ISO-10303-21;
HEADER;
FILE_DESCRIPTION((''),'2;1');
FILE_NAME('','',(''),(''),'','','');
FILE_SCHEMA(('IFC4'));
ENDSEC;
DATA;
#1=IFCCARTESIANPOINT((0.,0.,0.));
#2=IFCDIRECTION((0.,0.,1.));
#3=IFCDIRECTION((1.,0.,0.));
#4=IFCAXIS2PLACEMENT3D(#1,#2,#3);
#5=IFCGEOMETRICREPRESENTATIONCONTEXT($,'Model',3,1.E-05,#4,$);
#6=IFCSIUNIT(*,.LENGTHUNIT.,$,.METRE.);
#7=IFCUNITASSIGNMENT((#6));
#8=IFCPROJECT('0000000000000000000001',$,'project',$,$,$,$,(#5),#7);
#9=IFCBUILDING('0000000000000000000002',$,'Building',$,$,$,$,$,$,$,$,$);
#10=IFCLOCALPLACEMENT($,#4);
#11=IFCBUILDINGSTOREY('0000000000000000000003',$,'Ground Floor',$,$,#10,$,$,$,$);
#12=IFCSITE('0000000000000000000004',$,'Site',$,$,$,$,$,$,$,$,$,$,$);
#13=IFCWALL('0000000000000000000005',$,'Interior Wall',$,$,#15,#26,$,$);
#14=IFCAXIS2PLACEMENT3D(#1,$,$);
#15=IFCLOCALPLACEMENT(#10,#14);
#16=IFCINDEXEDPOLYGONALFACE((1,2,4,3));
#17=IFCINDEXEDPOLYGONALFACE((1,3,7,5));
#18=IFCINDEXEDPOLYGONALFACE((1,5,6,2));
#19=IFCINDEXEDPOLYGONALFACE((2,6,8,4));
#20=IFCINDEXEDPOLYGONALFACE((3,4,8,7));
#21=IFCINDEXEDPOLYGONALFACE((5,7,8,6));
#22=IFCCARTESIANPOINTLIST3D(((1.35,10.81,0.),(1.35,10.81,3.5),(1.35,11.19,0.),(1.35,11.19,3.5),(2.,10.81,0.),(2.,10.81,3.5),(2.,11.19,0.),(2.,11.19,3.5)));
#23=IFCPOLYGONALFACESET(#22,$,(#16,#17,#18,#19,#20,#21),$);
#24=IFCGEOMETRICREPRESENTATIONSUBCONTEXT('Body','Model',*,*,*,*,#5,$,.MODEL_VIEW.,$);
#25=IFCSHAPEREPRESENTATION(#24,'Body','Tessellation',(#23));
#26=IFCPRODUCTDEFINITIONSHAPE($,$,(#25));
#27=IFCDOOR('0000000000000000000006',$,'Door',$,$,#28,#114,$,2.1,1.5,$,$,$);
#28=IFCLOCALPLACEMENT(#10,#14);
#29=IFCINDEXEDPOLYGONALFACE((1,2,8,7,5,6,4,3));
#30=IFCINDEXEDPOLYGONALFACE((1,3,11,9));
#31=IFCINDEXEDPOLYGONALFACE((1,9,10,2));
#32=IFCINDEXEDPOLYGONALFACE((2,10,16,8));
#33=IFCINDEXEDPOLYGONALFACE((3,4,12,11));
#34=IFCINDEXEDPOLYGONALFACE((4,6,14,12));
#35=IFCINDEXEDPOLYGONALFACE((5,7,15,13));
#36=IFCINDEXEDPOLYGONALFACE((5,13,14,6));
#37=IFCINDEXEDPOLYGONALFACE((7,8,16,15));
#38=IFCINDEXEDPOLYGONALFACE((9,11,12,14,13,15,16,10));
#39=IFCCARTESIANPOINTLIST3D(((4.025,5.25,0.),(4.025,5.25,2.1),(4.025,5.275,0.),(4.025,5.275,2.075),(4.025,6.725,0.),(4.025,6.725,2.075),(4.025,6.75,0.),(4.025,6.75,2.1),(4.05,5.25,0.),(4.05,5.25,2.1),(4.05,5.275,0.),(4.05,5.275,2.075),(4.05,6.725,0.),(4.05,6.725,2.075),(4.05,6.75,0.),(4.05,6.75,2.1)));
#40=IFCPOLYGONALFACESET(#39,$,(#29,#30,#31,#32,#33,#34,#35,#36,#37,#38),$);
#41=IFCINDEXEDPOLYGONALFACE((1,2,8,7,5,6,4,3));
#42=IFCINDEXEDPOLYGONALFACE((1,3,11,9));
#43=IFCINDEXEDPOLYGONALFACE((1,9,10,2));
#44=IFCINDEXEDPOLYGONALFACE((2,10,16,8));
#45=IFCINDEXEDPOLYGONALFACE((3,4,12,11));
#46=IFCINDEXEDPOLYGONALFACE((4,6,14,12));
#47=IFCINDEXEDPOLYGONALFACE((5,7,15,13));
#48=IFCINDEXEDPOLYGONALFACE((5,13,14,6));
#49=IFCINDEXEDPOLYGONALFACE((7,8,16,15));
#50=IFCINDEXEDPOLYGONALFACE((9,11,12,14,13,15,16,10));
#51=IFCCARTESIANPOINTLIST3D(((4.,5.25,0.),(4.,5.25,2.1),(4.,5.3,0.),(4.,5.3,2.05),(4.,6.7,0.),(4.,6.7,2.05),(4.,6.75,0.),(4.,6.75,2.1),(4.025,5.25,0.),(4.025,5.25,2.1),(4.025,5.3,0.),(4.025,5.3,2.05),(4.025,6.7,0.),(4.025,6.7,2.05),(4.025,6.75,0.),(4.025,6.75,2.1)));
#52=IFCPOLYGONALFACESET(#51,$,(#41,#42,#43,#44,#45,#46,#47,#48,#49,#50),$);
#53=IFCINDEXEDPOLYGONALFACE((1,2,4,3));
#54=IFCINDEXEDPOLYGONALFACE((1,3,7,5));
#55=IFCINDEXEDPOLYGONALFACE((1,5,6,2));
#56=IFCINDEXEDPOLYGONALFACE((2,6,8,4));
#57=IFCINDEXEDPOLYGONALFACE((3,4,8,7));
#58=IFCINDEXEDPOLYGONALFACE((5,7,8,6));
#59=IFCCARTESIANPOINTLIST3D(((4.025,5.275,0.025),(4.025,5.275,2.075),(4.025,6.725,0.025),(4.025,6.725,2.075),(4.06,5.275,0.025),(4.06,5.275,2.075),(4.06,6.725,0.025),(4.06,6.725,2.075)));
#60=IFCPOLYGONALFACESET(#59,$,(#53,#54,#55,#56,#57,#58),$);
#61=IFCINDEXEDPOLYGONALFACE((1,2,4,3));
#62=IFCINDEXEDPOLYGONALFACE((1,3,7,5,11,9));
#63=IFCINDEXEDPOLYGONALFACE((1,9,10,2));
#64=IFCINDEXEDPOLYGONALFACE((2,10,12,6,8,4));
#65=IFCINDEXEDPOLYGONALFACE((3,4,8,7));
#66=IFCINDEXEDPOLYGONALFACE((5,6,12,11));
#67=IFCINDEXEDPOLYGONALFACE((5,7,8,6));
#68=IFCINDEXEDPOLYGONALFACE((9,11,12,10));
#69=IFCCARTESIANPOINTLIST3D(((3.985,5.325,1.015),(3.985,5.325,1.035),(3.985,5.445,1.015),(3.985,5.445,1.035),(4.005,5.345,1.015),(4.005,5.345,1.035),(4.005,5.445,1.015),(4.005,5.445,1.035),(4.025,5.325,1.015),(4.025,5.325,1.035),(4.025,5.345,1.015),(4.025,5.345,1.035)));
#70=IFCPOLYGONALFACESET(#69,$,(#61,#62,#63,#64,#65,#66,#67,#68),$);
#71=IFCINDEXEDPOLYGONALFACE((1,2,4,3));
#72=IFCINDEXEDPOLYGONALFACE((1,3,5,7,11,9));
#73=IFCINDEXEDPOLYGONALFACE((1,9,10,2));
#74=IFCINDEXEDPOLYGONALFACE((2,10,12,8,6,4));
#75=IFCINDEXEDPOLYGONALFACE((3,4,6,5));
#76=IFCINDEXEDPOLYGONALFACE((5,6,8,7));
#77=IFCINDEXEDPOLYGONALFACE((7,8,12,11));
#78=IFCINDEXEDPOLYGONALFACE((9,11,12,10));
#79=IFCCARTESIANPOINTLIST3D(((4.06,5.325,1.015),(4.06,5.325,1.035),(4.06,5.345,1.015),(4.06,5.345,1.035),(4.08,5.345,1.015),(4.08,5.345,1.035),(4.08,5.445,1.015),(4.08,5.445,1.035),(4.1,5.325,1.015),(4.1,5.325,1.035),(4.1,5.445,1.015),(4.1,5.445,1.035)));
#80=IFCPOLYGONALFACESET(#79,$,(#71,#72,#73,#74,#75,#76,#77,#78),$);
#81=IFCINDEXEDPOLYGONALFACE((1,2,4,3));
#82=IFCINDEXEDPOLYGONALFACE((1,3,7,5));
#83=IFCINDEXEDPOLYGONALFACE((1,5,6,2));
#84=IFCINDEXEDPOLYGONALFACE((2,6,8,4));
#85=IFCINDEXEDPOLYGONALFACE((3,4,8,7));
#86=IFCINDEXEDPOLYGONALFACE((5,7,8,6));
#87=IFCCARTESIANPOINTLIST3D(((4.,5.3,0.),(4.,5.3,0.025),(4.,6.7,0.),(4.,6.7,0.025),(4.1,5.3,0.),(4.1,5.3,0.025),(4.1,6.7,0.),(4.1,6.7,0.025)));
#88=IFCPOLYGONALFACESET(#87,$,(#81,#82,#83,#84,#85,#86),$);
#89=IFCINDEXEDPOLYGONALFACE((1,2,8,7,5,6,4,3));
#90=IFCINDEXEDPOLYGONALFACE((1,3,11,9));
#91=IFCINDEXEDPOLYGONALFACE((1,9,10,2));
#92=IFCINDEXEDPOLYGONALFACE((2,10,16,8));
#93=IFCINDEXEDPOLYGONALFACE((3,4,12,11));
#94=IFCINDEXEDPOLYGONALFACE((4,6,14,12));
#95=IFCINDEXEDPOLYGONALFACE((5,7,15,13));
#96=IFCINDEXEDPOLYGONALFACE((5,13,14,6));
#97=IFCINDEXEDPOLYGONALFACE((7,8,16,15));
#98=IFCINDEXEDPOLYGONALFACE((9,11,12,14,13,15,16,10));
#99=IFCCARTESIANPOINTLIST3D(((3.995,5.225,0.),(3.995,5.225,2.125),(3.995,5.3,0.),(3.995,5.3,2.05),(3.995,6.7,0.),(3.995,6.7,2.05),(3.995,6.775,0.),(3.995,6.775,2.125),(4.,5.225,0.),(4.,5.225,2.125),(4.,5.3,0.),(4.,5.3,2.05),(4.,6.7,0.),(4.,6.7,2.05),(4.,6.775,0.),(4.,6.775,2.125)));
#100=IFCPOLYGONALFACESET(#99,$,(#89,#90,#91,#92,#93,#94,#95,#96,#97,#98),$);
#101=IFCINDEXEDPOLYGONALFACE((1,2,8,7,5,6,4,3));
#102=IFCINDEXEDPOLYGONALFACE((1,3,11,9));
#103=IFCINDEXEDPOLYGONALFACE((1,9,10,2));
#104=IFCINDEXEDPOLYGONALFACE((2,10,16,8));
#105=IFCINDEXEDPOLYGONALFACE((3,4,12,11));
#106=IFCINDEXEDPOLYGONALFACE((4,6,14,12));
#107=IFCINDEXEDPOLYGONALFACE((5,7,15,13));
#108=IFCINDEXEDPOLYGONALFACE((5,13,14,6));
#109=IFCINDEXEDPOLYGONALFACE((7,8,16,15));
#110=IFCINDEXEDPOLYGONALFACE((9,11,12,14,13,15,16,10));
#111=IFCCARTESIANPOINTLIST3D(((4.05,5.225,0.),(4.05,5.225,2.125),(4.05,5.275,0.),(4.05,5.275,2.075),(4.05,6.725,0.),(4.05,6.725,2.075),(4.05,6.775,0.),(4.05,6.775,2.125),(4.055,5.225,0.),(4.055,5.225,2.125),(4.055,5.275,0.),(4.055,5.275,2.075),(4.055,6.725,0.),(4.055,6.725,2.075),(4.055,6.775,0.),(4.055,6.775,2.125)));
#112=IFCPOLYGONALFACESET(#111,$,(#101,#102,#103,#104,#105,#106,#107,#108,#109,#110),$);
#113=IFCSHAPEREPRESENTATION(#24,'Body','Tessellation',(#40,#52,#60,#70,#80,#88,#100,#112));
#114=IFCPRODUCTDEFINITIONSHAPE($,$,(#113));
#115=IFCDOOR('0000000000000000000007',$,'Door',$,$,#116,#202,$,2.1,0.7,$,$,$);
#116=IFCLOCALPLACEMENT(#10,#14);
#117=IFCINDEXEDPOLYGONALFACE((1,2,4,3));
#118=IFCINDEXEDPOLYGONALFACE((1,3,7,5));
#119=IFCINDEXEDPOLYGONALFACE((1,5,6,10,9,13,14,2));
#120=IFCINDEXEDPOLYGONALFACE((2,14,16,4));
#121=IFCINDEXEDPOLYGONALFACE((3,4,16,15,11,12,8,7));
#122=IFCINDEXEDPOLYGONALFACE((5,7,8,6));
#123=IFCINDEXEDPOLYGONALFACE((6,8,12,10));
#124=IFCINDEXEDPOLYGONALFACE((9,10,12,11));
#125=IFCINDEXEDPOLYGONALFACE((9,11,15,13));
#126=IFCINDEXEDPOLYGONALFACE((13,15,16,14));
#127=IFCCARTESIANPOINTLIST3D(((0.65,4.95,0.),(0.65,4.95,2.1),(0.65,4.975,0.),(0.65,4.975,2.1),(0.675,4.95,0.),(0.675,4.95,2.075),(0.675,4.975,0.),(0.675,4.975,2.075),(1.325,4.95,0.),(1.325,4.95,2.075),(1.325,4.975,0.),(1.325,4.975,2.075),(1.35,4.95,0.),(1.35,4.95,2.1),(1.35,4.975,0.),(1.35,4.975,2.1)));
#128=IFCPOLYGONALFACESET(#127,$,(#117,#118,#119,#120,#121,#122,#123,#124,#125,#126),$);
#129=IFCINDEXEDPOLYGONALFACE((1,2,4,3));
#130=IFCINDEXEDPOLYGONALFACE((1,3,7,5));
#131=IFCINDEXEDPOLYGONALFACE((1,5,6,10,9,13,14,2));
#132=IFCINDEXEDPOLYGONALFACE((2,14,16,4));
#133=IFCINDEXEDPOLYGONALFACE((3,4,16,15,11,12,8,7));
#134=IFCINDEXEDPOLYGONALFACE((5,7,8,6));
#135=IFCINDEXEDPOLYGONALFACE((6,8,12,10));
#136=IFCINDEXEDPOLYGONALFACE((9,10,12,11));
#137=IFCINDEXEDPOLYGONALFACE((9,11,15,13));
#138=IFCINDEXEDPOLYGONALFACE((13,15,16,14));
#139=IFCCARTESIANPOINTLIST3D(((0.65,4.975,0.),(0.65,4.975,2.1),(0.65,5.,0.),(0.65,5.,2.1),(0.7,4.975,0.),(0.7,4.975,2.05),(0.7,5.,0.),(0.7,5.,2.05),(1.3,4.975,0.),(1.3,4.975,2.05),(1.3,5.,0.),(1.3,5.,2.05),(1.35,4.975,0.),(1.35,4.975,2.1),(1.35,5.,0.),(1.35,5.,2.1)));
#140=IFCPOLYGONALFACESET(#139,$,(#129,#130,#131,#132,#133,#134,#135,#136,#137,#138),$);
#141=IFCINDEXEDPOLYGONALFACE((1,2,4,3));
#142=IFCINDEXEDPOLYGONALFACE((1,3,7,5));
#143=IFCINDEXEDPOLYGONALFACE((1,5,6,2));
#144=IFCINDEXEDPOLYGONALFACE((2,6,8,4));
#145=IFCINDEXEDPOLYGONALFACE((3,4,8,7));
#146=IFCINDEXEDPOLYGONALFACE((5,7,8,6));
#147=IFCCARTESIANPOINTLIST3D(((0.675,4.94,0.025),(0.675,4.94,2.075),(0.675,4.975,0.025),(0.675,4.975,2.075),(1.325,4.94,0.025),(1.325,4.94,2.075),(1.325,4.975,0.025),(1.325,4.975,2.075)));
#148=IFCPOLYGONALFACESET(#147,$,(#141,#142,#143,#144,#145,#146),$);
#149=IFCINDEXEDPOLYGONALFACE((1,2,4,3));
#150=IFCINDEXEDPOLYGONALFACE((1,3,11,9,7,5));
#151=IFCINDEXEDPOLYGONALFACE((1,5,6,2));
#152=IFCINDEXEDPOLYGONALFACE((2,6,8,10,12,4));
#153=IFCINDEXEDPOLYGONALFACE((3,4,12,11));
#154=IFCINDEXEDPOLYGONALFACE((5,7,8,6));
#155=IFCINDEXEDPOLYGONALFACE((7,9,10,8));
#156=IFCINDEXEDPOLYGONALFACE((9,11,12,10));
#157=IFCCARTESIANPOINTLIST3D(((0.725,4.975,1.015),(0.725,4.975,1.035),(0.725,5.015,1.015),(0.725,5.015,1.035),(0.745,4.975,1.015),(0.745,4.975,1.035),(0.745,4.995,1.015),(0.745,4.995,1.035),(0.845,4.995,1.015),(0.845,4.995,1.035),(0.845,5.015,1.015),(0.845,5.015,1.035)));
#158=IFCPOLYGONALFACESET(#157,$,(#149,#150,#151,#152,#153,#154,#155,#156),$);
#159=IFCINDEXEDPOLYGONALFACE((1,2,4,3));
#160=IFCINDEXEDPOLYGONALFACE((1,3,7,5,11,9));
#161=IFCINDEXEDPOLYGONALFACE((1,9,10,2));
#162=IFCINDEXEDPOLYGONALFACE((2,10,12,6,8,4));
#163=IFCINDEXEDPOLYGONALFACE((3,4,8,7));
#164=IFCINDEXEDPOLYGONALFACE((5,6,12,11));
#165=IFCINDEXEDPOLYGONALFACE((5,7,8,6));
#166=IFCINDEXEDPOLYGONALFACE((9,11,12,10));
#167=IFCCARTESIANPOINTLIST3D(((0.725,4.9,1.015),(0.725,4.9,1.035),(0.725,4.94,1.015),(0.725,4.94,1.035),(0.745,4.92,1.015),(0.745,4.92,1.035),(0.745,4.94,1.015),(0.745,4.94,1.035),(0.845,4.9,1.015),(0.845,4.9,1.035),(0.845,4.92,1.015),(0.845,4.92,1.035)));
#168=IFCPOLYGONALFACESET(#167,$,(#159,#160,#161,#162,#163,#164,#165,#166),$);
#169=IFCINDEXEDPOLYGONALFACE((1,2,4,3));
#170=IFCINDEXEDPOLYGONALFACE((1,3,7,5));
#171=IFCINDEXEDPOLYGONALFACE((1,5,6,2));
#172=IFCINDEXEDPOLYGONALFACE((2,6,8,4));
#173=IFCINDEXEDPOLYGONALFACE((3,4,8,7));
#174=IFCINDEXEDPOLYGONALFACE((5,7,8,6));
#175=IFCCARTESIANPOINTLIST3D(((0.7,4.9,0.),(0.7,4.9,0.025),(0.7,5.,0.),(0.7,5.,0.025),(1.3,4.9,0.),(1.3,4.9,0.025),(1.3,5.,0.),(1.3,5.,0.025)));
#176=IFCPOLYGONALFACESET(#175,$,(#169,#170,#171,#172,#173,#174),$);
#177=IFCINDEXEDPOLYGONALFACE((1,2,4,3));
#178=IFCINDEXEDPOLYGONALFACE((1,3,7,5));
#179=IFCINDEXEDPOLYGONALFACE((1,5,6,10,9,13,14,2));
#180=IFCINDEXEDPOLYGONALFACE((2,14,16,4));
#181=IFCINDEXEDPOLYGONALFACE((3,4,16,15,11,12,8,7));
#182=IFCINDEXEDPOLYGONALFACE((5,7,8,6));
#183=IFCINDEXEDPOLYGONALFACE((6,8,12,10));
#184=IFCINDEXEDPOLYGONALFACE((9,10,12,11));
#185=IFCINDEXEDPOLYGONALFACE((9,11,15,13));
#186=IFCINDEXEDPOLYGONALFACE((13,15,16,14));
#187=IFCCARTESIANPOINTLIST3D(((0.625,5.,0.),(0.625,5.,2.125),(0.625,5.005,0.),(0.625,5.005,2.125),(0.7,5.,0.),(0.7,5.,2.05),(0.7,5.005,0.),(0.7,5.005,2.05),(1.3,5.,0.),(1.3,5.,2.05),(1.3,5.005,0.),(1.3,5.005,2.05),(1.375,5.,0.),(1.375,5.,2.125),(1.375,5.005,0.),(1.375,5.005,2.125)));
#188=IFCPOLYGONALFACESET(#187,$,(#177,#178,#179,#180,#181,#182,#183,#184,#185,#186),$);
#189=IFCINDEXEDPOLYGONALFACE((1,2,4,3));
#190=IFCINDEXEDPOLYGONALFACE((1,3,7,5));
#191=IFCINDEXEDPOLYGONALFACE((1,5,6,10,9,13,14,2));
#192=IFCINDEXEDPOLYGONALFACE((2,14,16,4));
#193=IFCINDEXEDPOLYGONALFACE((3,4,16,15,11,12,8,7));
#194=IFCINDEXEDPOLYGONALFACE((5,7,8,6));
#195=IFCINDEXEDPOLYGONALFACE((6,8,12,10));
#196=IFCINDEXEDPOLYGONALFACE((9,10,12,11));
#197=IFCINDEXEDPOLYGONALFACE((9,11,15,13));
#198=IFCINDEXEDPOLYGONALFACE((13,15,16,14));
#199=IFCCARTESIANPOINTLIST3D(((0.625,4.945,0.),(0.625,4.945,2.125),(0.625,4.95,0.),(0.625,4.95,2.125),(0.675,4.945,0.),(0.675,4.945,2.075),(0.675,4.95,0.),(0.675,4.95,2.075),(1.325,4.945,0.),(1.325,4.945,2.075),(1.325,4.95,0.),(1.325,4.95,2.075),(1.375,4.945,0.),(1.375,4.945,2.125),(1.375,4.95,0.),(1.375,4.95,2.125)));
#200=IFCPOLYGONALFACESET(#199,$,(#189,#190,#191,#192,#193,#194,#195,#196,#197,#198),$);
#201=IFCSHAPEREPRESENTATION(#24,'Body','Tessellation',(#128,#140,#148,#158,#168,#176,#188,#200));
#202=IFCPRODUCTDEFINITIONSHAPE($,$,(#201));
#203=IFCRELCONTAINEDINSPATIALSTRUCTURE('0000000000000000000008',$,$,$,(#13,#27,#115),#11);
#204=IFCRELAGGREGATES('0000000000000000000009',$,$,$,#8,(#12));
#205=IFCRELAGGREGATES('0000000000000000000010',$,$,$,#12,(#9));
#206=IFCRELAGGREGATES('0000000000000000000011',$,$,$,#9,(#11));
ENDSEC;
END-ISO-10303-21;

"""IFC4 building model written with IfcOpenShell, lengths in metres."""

from ifc_helpers import new_model, si_unit, frame, origin_with_axes, place, context, subcontext, project, spatial, line, indexed_curve, outline, extrude, element, save


model = new_model("IFC4")

# Units and contexts
model_context = context("Model", 3, precision=1e-05, world=origin_with_axes())
body_context = subcontext(model_context, "Body", "Model", "MODEL_VIEW")
ifc_project = project(units=[si_unit("LENGTHUNIT", "METRE")], contexts=[model_context])

# Site, building, storey
site = spatial("IfcSite", under=ifc_project, Name="Site")
building = spatial("IfcBuilding", under=site, Name="Building")
storey_placement = place(None, origin_with_axes())
storey = spatial("IfcBuildingStorey", under=building, at=storey_placement, Name="Ground Floor")

# Wall
wall_1_placement = place(storey_placement, frame((1.35, 11.0, 0.0), z_axis=(0.0, 0.0, 1.0), x_axis=(1.0, 0.0, 0.0)))
element("IfcWall", 1, at=wall_1_placement, inside=storey, Name="Interior Wall", context=body_context, shape_type="SweptSolid", body=[
    extrude(outline(indexed_curve([(0.0, 0.0), (0.0, 0.38), (0.65, 0.38), (0.65, 0.0), (0.0, 0.0)], self_intersect=False)), frame((0.0, -0.19, 0.0), z_axis=(0.0, 0.0, 1.0), x_axis=(1.0, 0.0, 0.0)), (0.0, 0.0, 1.0), 3.5),
])

# Doors
door_1_placement = place(storey_placement, frame((4.0, 6.75, 0.0), z_axis=(0.0, 0.0, 1.0), x_axis=(0.0, -1.0, 0.0)))
element("IfcDoor", 2, at=door_1_placement, inside=storey, Name="Door", OverallHeight=2.1, OverallWidth=1.5, context=body_context, shape_type="SweptSolid", body=[
    extrude(outline(indexed_curve([(0.0, 0.0), (0.0, 2.1), (1.5, 2.1), (1.5, 0.0), (1.475, 0.0), (1.475, 2.075), (0.025, 2.075), (0.025, 0.0)], segments=[line(1, 2, 3, 4, 5, 6, 7, 8, 1)])), frame((0.0, 0.025, 0.0), z_axis=(0.0, -1.0, 0.0), x_axis=(1.0, 0.0, 0.0)), (0.0, 0.0, -1.0), 0.025),
    extrude(outline(indexed_curve([(0.0, 0.0), (0.0, 2.1), (1.5, 2.1), (1.5, 0.0), (1.45, 0.0), (1.45, 2.05), (0.05, 2.05), (0.05, 0.0)], segments=[line(1, 2, 3, 4, 5, 6, 7, 8, 1)])), frame((0.0, 0.0, 0.0), z_axis=(0.0, -1.0, 0.0), x_axis=(1.0, 0.0, 0.0)), (0.0, 0.0, -1.0), 0.025),
    extrude(outline(indexed_curve([(0.0, 0.0), (1.45, 0.0), (1.45, 0.035), (0.0, 0.035)], segments=[line(1, 2, 3, 4, 1)])), frame((0.025, 0.025, 0.025), z_axis=(0.0, 0.0, 1.0), x_axis=(1.0, 0.0, 0.0)), (0.0, 0.0, 1.0), 2.05),
    extrude(outline(indexed_curve([(0.0, 0.0), (0.0, -0.04), (-0.12, -0.04), (-0.12, -0.02), (-0.02, -0.02), (-0.02, 0.0)], segments=[line(1, 2, 3, 4, 5, 6, 1)])), frame((1.425, 0.025, 1.015), z_axis=(0.0, 0.0, 1.0), x_axis=(1.0, 0.0, 0.0)), (0.0, 0.0, 1.0), 0.02),
    extrude(outline(indexed_curve([(0.0, 0.0), (0.0, 0.04), (-0.12, 0.04), (-0.12, 0.02), (-0.02, 0.02), (-0.02, 0.0)], segments=[line(1, 2, 3, 4, 5, 6, 1)])), frame((1.425, 0.06, 1.015), z_axis=(0.0, 0.0, 1.0), x_axis=(1.0, 0.0, 0.0)), (0.0, 0.0, 1.0), 0.02),
    extrude(outline(indexed_curve([(0.0, 0.0), (1.4, 0.0), (1.4, 0.1), (0.0, 0.1)], segments=[line(1, 2, 3, 4, 1)])), frame((0.05, 0.0, 0.0), z_axis=(0.0, 0.0, 1.0), x_axis=(1.0, 0.0, 0.0)), (0.0, 0.0, 1.0), 0.025),
    extrude(outline(indexed_curve([(0.0, 0.0), (0.0, 2.125), (1.55, 2.125), (1.55, 0.0), (1.475, 0.0), (1.475, 2.05), (0.075, 2.05), (0.075, 0.0)], segments=[line(1, 2, 3, 4, 5, 6, 7, 8, 1)])), frame((-0.025, -0.005, 0.0), z_axis=(0.0, -1.0, 0.0), x_axis=(1.0, 0.0, 0.0)), (0.0, 0.0, -1.0), 0.005),
    extrude(outline(indexed_curve([(0.0, 0.0), (0.0, 2.125), (1.55, 2.125), (1.55, 0.0), (1.5, 0.0), (1.5, 2.075), (0.05, 2.075), (0.05, 0.0)], segments=[line(1, 2, 3, 4, 5, 6, 7, 8, 1)])), frame((-0.025, 0.05, 0.0), z_axis=(0.0, -1.0, 0.0), x_axis=(1.0, 0.0, 0.0)), (0.0, 0.0, -1.0), 0.005),
])
door_2_placement = place(storey_placement, frame((1.35, 5.0, 0.0), z_axis=(0.0, 0.0, 1.0), x_axis=(-1.0, 0.0, 0.0)))
element("IfcDoor", 3, at=door_2_placement, inside=storey, Name="Door", OverallHeight=2.1, OverallWidth=0.7, context=body_context, shape_type="SweptSolid", body=[
    extrude(outline(indexed_curve([(0.0, 0.0), (0.0, 2.1), (0.7, 2.1), (0.7, 0.0), (0.675, 0.0), (0.675, 2.075), (0.025, 2.075), (0.025, 0.0)], segments=[line(1, 2, 3, 4, 5, 6, 7, 8, 1)])), frame((0.0, 0.025, 0.0), z_axis=(0.0, -1.0, 0.0), x_axis=(1.0, 0.0, 0.0)), (0.0, 0.0, -1.0), 0.025),
    extrude(outline(indexed_curve([(0.0, 0.0), (0.0, 2.1), (0.7, 2.1), (0.7, 0.0), (0.65, 0.0), (0.65, 2.05), (0.05, 2.05), (0.05, 0.0)], segments=[line(1, 2, 3, 4, 5, 6, 7, 8, 1)])), frame((0.0, 0.0, 0.0), z_axis=(0.0, -1.0, 0.0), x_axis=(1.0, 0.0, 0.0)), (0.0, 0.0, -1.0), 0.025),
    extrude(outline(indexed_curve([(0.0, 0.0), (0.65, 0.0), (0.65, 0.035), (0.0, 0.035)], segments=[line(1, 2, 3, 4, 1)])), frame((0.025, 0.025, 0.025), z_axis=(0.0, 0.0, 1.0), x_axis=(1.0, 0.0, 0.0)), (0.0, 0.0, 1.0), 2.05),
    extrude(outline(indexed_curve([(0.0, 0.0), (0.0, -0.04), (-0.12, -0.04), (-0.12, -0.02), (-0.02, -0.02), (-0.02, 0.0)], segments=[line(1, 2, 3, 4, 5, 6, 1)])), frame((0.625, 0.025, 1.015), z_axis=(0.0, 0.0, 1.0), x_axis=(1.0, 0.0, 0.0)), (0.0, 0.0, 1.0), 0.02),
    extrude(outline(indexed_curve([(0.0, 0.0), (0.0, 0.04), (-0.12, 0.04), (-0.12, 0.02), (-0.02, 0.02), (-0.02, 0.0)], segments=[line(1, 2, 3, 4, 5, 6, 1)])), frame((0.625, 0.06, 1.015), z_axis=(0.0, 0.0, 1.0), x_axis=(1.0, 0.0, 0.0)), (0.0, 0.0, 1.0), 0.02),
    extrude(outline(indexed_curve([(0.0, 0.0), (0.6, 0.0), (0.6, 0.1), (0.0, 0.1)], segments=[line(1, 2, 3, 4, 1)])), frame((0.05, 0.0, 0.0), z_axis=(0.0, 0.0, 1.0), x_axis=(1.0, 0.0, 0.0)), (0.0, 0.0, 1.0), 0.025),
    extrude(outline(indexed_curve([(0.0, 0.0), (0.0, 2.125), (0.75, 2.125), (0.75, 0.0), (0.675, 0.0), (0.675, 2.05), (0.075, 2.05), (0.075, 0.0)], segments=[line(1, 2, 3, 4, 5, 6, 7, 8, 1)])), frame((-0.025, -0.005, 0.0), z_axis=(0.0, -1.0, 0.0), x_axis=(1.0, 0.0, 0.0)), (0.0, 0.0, -1.0), 0.005),
    extrude(outline(indexed_curve([(0.0, 0.0), (0.0, 2.125), (0.75, 2.125), (0.75, 0.0), (0.7, 0.0), (0.7, 2.075), (0.05, 2.075), (0.05, 0.0)], segments=[line(1, 2, 3, 4, 5, 6, 7, 8, 1)])), frame((-0.025, 0.05, 0.0), z_axis=(0.0, -1.0, 0.0), x_axis=(1.0, 0.0, 0.0)), (0.0, 0.0, -1.0), 0.005),
])

save(model, "model.ifc")
